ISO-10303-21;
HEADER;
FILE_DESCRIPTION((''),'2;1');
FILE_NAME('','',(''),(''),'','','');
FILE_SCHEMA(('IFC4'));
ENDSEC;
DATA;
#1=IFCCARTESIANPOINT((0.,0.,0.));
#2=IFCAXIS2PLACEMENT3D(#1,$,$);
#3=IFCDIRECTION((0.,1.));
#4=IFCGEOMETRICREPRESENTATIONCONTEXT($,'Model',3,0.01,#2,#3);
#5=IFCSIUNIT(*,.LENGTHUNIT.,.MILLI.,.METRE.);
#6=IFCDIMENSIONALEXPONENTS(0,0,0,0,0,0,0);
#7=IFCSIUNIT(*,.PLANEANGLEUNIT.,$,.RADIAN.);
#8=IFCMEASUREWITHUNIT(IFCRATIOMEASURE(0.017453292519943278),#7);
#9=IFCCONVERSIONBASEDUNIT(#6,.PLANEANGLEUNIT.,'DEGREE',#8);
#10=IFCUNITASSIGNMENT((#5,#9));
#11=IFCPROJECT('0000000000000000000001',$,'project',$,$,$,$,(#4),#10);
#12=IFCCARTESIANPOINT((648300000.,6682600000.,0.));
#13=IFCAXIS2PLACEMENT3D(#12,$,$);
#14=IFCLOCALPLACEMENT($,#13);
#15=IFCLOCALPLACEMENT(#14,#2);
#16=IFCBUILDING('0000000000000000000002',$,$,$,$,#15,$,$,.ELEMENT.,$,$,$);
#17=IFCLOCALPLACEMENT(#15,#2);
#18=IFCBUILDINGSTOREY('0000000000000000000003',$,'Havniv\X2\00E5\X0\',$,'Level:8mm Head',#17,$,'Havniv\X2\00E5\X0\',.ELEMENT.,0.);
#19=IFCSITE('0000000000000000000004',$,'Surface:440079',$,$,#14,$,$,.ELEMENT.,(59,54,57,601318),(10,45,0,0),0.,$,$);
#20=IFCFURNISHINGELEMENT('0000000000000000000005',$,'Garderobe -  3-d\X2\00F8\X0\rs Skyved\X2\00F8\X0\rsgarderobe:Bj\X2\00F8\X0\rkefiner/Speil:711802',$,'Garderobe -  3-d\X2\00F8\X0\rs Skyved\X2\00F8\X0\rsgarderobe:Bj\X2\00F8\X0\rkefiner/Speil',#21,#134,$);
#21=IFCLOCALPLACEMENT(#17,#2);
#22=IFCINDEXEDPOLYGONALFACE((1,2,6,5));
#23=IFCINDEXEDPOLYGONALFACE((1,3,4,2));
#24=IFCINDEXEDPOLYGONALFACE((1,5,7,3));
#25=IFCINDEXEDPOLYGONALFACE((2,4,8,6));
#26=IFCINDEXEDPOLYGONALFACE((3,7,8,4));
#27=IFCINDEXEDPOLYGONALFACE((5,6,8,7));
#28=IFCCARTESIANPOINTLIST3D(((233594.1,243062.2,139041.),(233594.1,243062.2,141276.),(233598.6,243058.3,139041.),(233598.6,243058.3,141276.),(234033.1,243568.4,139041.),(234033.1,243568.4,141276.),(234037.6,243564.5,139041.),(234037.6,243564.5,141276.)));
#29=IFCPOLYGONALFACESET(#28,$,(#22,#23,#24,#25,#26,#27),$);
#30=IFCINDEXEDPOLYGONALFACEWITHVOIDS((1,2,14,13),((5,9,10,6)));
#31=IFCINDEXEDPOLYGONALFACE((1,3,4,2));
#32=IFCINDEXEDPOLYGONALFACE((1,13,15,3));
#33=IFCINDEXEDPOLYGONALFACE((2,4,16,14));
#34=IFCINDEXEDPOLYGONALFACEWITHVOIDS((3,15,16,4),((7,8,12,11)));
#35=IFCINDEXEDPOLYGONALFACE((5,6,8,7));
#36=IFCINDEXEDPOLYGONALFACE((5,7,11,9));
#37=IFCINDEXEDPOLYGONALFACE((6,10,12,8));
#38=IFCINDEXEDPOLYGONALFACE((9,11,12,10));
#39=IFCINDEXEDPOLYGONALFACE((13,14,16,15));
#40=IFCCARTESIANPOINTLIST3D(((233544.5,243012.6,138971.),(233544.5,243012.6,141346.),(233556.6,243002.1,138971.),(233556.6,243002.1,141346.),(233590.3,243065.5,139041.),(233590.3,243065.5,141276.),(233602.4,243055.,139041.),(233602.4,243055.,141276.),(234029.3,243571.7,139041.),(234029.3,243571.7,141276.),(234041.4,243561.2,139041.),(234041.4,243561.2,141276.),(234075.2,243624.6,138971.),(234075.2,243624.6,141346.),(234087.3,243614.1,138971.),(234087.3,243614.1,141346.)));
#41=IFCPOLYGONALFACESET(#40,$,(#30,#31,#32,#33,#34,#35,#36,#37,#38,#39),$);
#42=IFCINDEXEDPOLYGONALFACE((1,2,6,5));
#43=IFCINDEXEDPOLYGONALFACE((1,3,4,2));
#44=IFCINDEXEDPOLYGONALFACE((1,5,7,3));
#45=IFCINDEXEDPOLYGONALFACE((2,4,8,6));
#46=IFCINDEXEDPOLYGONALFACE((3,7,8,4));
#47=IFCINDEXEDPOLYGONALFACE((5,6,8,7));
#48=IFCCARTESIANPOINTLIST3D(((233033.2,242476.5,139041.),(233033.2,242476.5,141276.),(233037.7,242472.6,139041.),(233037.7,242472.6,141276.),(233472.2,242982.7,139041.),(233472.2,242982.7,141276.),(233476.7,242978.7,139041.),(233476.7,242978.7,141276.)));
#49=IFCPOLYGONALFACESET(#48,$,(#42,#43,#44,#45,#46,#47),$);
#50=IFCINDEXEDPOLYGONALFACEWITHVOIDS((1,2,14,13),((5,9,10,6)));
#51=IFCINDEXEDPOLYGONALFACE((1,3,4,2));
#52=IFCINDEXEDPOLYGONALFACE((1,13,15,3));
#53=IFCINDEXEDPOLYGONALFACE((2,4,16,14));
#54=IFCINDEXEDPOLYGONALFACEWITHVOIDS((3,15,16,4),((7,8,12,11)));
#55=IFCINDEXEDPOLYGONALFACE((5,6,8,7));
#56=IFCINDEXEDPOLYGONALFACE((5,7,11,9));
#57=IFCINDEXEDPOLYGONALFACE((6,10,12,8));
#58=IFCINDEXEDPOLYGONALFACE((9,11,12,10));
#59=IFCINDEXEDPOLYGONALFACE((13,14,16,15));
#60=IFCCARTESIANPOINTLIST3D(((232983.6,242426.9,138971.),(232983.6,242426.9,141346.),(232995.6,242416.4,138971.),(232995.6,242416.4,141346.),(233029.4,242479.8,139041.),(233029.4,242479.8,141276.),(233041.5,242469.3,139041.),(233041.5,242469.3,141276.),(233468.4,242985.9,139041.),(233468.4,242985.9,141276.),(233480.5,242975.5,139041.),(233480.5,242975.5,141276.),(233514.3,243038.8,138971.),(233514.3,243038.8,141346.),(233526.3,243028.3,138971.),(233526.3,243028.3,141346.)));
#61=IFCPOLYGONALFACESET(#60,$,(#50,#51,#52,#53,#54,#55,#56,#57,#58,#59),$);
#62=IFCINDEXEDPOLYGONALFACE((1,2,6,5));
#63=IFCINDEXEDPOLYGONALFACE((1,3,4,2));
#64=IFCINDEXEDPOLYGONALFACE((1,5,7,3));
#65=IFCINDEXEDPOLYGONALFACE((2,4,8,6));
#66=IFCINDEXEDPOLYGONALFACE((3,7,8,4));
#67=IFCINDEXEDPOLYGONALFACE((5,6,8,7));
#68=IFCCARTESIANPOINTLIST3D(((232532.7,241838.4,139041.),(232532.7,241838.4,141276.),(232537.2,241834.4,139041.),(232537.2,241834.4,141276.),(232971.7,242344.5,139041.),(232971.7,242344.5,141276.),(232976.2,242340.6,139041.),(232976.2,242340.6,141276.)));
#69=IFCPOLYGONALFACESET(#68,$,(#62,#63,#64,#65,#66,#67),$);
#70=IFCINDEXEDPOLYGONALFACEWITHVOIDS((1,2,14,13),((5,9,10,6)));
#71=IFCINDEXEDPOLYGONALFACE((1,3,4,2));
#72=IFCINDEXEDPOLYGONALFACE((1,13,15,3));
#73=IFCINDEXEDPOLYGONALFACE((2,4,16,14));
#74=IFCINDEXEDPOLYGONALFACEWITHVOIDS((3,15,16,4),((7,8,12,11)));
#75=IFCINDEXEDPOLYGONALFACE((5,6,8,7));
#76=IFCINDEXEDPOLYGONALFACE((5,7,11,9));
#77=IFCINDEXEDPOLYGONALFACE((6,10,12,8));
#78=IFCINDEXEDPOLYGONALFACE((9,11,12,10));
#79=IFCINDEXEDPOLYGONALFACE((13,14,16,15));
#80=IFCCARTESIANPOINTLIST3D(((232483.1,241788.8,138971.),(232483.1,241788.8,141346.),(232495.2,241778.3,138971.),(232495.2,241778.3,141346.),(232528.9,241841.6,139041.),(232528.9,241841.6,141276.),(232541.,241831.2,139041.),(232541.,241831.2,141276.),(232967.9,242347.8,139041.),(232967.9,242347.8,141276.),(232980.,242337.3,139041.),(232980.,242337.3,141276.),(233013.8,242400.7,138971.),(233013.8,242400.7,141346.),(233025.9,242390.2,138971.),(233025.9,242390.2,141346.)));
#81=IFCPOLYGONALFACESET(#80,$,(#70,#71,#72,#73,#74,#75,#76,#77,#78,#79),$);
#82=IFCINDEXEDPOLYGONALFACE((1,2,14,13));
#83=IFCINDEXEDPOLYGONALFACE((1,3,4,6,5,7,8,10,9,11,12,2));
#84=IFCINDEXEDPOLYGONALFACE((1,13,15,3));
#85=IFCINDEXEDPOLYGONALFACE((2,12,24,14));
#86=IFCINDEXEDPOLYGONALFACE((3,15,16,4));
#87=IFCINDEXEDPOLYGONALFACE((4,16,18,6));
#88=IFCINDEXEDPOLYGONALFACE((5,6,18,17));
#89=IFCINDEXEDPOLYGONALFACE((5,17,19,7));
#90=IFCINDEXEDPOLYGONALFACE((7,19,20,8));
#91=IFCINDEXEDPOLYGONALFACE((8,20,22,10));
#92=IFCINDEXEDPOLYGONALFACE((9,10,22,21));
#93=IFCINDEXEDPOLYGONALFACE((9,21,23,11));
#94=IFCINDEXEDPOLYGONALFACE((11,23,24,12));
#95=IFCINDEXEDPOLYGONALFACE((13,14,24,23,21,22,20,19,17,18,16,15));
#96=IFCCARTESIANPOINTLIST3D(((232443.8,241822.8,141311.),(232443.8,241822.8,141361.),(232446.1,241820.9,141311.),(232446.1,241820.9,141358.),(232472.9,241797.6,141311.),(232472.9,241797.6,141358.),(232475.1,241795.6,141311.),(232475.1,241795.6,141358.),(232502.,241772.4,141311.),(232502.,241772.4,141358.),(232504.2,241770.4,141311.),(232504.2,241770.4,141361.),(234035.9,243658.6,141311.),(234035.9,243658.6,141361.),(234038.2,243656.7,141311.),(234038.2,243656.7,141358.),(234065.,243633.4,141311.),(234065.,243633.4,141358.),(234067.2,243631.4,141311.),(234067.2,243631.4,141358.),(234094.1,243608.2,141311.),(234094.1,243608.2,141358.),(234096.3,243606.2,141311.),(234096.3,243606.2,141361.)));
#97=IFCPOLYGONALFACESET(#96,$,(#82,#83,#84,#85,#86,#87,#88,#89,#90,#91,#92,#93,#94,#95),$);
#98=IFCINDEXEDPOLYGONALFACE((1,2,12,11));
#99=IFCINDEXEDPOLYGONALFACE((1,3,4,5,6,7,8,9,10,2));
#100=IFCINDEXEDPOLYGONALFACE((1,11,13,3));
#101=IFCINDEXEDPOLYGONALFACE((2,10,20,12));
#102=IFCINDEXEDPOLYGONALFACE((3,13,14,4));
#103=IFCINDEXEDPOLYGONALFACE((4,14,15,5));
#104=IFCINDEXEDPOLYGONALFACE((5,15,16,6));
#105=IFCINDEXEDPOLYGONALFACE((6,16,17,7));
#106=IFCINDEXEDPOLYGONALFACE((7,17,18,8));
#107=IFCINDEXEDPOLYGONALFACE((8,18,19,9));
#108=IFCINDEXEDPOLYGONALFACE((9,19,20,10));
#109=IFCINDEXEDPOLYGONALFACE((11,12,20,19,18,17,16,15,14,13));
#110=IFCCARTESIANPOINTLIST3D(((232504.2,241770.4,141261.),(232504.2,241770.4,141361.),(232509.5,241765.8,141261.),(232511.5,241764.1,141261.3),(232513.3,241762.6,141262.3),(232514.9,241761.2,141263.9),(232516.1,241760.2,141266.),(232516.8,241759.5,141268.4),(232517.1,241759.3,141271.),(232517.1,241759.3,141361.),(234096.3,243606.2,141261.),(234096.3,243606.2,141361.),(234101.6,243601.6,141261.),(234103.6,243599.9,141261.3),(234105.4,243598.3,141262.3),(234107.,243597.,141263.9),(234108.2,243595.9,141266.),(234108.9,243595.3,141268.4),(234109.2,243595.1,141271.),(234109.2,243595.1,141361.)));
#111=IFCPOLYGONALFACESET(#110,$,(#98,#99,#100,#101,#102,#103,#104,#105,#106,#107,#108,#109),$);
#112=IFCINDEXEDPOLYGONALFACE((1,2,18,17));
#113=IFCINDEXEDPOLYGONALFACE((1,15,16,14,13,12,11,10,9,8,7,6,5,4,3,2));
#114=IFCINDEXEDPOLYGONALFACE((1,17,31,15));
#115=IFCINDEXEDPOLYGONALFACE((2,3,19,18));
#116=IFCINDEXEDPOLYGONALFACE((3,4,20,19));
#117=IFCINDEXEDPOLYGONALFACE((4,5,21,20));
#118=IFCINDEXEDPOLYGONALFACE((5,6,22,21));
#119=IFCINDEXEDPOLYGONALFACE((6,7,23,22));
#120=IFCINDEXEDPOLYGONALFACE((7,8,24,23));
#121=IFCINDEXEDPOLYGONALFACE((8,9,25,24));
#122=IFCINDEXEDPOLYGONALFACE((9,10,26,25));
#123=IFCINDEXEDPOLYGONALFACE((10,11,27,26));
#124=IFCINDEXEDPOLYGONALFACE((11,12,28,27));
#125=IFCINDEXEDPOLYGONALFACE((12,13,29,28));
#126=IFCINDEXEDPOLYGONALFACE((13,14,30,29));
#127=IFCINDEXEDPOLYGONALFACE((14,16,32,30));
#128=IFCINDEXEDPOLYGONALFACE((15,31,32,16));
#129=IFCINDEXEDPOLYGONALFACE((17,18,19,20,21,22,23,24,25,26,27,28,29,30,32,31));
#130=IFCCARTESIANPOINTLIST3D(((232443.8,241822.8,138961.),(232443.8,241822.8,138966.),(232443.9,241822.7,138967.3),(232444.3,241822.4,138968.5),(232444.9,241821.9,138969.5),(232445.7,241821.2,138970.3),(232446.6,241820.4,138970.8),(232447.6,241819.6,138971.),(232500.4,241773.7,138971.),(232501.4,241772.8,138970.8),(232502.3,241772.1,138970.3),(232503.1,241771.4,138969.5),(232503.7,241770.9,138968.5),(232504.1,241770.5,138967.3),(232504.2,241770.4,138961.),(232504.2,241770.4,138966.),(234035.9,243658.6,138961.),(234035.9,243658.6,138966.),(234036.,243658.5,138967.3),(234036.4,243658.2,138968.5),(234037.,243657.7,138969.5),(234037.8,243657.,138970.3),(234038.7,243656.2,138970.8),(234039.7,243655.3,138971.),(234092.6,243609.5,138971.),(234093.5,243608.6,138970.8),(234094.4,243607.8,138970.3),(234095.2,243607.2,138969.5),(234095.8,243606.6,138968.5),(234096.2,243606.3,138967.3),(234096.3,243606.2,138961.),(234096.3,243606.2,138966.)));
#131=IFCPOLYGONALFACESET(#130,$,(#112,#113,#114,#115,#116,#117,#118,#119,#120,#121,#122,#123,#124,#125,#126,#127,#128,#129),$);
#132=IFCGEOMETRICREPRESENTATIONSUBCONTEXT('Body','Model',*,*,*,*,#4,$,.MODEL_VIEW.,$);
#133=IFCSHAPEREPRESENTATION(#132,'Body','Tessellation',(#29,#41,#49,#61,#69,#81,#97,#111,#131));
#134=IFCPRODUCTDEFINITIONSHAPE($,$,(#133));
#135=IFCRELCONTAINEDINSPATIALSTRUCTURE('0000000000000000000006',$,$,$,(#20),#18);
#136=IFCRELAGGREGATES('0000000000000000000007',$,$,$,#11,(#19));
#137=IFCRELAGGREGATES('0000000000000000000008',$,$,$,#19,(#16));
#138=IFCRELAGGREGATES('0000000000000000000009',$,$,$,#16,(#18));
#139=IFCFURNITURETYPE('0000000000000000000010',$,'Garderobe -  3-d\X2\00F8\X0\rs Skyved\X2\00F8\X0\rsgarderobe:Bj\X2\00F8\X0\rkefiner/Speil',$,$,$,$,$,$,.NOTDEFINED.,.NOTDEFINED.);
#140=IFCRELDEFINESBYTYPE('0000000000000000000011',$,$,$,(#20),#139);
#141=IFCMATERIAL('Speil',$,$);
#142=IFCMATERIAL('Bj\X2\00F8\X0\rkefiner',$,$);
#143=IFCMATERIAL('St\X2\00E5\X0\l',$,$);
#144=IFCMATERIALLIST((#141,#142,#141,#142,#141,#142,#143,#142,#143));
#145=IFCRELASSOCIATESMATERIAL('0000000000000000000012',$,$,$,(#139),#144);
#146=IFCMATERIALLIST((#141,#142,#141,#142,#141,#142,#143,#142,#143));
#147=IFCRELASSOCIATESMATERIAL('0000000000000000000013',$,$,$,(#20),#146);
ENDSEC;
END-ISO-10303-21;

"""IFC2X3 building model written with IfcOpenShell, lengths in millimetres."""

from ifc_helpers import new_model, entity, si_unit, converted_unit, direction, frame, frame_2d, origin, origin_2d_with_axis, place, context, subcontext, project, spatial, polyline, circle_curve, parameter, trimmed, segment, composite_curve, rectangle, outline, extrude, source, transform, mapped, material, material_list, type_object, type_shapes, element, save


model = new_model("IFC2X3")

# Units and contexts
model_context = context("Model", 3, precision=0.01, world=origin(), true_north=direction((0.0, 1.0)))
body_context = subcontext(model_context, "Body", "Model", "MODEL_VIEW")
ifc_project = project(units=[si_unit("LENGTHUNIT", "METRE", prefix="MILLI"), converted_unit("PLANEANGLEUNIT", "DEGREE", entity("IfcRatioMeasure", 0.017453292519943278), si_unit("PLANEANGLEUNIT", "RADIAN"), dimensions=[0, 0, 0, 0, 0, 0, 0])], contexts=[model_context])

# Site, building, storey
site_placement = place(None, frame((648300000.0, 6682600000.0, 0.0)))
site = spatial("IfcSite", under=ifc_project, at=site_placement, Name="Surface:440079", CompositionType="ELEMENT", RefLatitude=(59, 54, 57, 601318), RefLongitude=(10, 45, 0, 0), RefElevation=0.0)
building_placement = place(site_placement, origin())
building = spatial("IfcBuilding", under=site, at=building_placement, CompositionType="ELEMENT")
storey_placement = place(building_placement, origin())
storey = spatial("IfcBuildingStorey", under=building, at=storey_placement, Name="Havnivå", ObjectType="Level:8mm Head", LongName="Havnivå", CompositionType="ELEMENT", Elevation=0.0)

# Furnishing element
ifc_material_1 = material(Name="Speil")
ifc_material_2 = material(Name="Bjørkefiner")
ifc_material_3 = material(Name="Stål")
ifc_material_list_1 = material_list([ifc_material_1, ifc_material_2, ifc_material_1, ifc_material_2, ifc_material_1, ifc_material_2, ifc_material_3, ifc_material_2, ifc_material_3])
ifc_material_list_2 = material_list([ifc_material_1, ifc_material_2, ifc_material_1, ifc_material_2, ifc_material_1, ifc_material_2, ifc_material_3, ifc_material_2, ifc_material_3])
furniture_type = type_object("IfcFurnitureType", Name="Garderobe -  3-dørs Skyvedørsgarderobe:Bjørkefiner/Speil", material=ifc_material_list_2)
shared_shape_1 = source(origin(), body_context, "Body", "SweptSolid", [
    extrude(rectangle(XDim=6.0, YDim=670.0, at=origin_2d_with_axis()), frame((1263.8, -191.2, 80.0), z_axis=(0.0, 0.0, 1.0), x_axis=(0.0, 1.0, 0.0)), (0.0, 0.0, 1.0), 2235.0),
    extrude(outline(polyline([(-1187.5, -405.0), (1187.5, -405.0), (1187.5, 405.0), (-1187.5, 405.0), (-1187.5, -405.0)]), holes=[polyline([(-1117.5, -335.0), (-1117.5, 335.0), (1117.5, 335.0), (1117.5, -335.0), (-1117.5, -335.0)])]), frame((1263.8, -199.2, 1197.5), z_axis=(0.0, 1.0, 0.0), x_axis=(0.0, 0.0, -1.0)), (0.0, 0.0, 1.0), 16.0),
    extrude(rectangle(XDim=6.0, YDim=670.0, at=frame_2d((0.0, 0.0), x_axis=(1.0, 0.0))), frame((453.8, -151.2, 80.0), z_axis=(0.0, 0.0, 1.0), x_axis=(0.0, 1.0, 0.0)), (0.0, 0.0, 1.0), 2235.0),
    extrude(outline(polyline([(-1187.5, -405.0), (1187.5, -405.0), (1187.5, 405.0), (-1187.5, 405.0), (-1187.5, -405.0)]), holes=[polyline([(-1117.5, -335.0), (-1117.5, 335.0), (1117.5, 335.0), (1117.5, -335.0), (-1117.5, -335.0)])]), frame((453.8, -159.2, 1197.5), z_axis=(0.0, 1.0, 0.0), x_axis=(0.0, 0.0, -1.0)), (0.0, 0.0, 1.0), 16.0),
    extrude(rectangle(XDim=6.0, YDim=670.0, at=origin_2d_with_axis()), frame((-356.2, -191.2, 80.0), z_axis=(0.0, 0.0, 1.0), x_axis=(0.0, 1.0, 0.0)), (0.0, 0.0, 1.0), 2235.0),
    extrude(outline(polyline([(-1187.5, -405.0), (1187.5, -405.0), (1187.5, 405.0), (-1187.5, 405.0), (-1187.5, -405.0)]), holes=[polyline([(-1117.5, -335.0), (-1117.5, 335.0), (1117.5, 335.0), (1117.5, -335.0), (-1117.5, -335.0)])]), frame((-356.2, -199.2, 1197.5), z_axis=(0.0, 1.0, 0.0), x_axis=(0.0, 0.0, -1.0)), (0.0, 0.0, 1.0), 16.0),
    extrude(outline(polyline([(-26.0, -40.0), (24.0, -40.0), (24.0, -37.0), (-23.0, -37.0), (-23.0, -1.5), (24.0, -1.5), (24.0, 1.5), (-23.0, 1.5), (-23.0, 37.0), (24.0, 37.0), (24.0, 40.0), (-26.0, 40.0), (-26.0, -40.0)])), frame((-761.2, -171.2, 2374.0), z_axis=(1.0, 0.0, 0.0), x_axis=(0.0, 0.0, -1.0)), (0.0, 0.0, 1.0), 2430.0),
    extrude(outline(composite_curve([segment(polyline([(-42.0, -8.2), (58.0, -8.2)]), True, "CONTINUOUS"), segment(polyline([(58.0, -8.2), (58.0, 8.8)]), True, "CONTINUOUS"), segment(polyline([(58.0, 8.8), (-32.0, 8.8)]), True, "CONTINUOUS"), segment(trimmed(circle_curve(frame_2d((-32.0, -1.2), x_axis=(0.0, -1.0)), 10.0), [parameter(180.0)], [parameter(270.0)], True, "PARAMETER"), True, "CONTINUOUS"), segment(polyline([(-42.0, -1.2), (-42.0, -8.2)]), True, "CONTINUOUS")], self_intersect=False)), frame((-761.2, -219.4, 2342.0), z_axis=(1.0, 0.0, 0.0), x_axis=(0.0, 0.0, 1.0)), (0.0, 0.0, 1.0), 2430.0),
    extrude(outline(composite_curve([segment(polyline([(-35.0, -5.0), (35.0, -5.0)]), True, "CONTINUOUS"), segment(trimmed(circle_curve(frame_2d((35.0, 0.0), x_axis=(-1.0, 0.0)), 5.0), [parameter(90.0)], [parameter(180.0)], True, "PARAMETER"), True, "CONTINUOUS"), segment(polyline([(40.0, 0.0), (40.0, 5.0)]), True, "CONTINUOUS"), segment(polyline([(40.0, 5.0), (-40.0, 5.0)]), True, "CONTINUOUS"), segment(polyline([(-40.0, 5.0), (-40.0, 0.0)]), True, "CONTINUOUS"), segment(trimmed(circle_curve(frame_2d((-35.0, 0.0), x_axis=(-1.0, 0.0)), 5.0), [parameter(360.0)], [parameter(90.0)], True, "PARAMETER"), True, "CONTINUOUS")], self_intersect=False)), frame((-761.2, -171.2, 5.0), z_axis=(1.0, 0.0, 0.0), x_axis=(0.0, -1.0, 0.0)), (0.0, 0.0, 1.0), 2430.0),
])
type_shapes(furniture_type, [shared_shape_1])
furnishing_placement = place(storey_placement, frame((232843.4, 242483.8, 138961.0), z_axis=(0.0, 0.0, 1.0), x_axis=(0.655187, 0.755467, 0.0)))
element("IfcFurnishingElement", 1, at=furnishing_placement, inside=storey, type_object=furniture_type, material=ifc_material_list_1, Name="Garderobe -  3-dørs Skyvedørsgarderobe:Bjørkefiner/Speil:711802", ObjectType="Garderobe -  3-dørs Skyvedørsgarderobe:Bjørkefiner/Speil", context=body_context, shape_type="MappedRepresentation", body=[
    mapped(shared_shape_1, transform((0.0, 0.0, 0.0), scale=1.0)),
])

save(model, "model.ifc")
